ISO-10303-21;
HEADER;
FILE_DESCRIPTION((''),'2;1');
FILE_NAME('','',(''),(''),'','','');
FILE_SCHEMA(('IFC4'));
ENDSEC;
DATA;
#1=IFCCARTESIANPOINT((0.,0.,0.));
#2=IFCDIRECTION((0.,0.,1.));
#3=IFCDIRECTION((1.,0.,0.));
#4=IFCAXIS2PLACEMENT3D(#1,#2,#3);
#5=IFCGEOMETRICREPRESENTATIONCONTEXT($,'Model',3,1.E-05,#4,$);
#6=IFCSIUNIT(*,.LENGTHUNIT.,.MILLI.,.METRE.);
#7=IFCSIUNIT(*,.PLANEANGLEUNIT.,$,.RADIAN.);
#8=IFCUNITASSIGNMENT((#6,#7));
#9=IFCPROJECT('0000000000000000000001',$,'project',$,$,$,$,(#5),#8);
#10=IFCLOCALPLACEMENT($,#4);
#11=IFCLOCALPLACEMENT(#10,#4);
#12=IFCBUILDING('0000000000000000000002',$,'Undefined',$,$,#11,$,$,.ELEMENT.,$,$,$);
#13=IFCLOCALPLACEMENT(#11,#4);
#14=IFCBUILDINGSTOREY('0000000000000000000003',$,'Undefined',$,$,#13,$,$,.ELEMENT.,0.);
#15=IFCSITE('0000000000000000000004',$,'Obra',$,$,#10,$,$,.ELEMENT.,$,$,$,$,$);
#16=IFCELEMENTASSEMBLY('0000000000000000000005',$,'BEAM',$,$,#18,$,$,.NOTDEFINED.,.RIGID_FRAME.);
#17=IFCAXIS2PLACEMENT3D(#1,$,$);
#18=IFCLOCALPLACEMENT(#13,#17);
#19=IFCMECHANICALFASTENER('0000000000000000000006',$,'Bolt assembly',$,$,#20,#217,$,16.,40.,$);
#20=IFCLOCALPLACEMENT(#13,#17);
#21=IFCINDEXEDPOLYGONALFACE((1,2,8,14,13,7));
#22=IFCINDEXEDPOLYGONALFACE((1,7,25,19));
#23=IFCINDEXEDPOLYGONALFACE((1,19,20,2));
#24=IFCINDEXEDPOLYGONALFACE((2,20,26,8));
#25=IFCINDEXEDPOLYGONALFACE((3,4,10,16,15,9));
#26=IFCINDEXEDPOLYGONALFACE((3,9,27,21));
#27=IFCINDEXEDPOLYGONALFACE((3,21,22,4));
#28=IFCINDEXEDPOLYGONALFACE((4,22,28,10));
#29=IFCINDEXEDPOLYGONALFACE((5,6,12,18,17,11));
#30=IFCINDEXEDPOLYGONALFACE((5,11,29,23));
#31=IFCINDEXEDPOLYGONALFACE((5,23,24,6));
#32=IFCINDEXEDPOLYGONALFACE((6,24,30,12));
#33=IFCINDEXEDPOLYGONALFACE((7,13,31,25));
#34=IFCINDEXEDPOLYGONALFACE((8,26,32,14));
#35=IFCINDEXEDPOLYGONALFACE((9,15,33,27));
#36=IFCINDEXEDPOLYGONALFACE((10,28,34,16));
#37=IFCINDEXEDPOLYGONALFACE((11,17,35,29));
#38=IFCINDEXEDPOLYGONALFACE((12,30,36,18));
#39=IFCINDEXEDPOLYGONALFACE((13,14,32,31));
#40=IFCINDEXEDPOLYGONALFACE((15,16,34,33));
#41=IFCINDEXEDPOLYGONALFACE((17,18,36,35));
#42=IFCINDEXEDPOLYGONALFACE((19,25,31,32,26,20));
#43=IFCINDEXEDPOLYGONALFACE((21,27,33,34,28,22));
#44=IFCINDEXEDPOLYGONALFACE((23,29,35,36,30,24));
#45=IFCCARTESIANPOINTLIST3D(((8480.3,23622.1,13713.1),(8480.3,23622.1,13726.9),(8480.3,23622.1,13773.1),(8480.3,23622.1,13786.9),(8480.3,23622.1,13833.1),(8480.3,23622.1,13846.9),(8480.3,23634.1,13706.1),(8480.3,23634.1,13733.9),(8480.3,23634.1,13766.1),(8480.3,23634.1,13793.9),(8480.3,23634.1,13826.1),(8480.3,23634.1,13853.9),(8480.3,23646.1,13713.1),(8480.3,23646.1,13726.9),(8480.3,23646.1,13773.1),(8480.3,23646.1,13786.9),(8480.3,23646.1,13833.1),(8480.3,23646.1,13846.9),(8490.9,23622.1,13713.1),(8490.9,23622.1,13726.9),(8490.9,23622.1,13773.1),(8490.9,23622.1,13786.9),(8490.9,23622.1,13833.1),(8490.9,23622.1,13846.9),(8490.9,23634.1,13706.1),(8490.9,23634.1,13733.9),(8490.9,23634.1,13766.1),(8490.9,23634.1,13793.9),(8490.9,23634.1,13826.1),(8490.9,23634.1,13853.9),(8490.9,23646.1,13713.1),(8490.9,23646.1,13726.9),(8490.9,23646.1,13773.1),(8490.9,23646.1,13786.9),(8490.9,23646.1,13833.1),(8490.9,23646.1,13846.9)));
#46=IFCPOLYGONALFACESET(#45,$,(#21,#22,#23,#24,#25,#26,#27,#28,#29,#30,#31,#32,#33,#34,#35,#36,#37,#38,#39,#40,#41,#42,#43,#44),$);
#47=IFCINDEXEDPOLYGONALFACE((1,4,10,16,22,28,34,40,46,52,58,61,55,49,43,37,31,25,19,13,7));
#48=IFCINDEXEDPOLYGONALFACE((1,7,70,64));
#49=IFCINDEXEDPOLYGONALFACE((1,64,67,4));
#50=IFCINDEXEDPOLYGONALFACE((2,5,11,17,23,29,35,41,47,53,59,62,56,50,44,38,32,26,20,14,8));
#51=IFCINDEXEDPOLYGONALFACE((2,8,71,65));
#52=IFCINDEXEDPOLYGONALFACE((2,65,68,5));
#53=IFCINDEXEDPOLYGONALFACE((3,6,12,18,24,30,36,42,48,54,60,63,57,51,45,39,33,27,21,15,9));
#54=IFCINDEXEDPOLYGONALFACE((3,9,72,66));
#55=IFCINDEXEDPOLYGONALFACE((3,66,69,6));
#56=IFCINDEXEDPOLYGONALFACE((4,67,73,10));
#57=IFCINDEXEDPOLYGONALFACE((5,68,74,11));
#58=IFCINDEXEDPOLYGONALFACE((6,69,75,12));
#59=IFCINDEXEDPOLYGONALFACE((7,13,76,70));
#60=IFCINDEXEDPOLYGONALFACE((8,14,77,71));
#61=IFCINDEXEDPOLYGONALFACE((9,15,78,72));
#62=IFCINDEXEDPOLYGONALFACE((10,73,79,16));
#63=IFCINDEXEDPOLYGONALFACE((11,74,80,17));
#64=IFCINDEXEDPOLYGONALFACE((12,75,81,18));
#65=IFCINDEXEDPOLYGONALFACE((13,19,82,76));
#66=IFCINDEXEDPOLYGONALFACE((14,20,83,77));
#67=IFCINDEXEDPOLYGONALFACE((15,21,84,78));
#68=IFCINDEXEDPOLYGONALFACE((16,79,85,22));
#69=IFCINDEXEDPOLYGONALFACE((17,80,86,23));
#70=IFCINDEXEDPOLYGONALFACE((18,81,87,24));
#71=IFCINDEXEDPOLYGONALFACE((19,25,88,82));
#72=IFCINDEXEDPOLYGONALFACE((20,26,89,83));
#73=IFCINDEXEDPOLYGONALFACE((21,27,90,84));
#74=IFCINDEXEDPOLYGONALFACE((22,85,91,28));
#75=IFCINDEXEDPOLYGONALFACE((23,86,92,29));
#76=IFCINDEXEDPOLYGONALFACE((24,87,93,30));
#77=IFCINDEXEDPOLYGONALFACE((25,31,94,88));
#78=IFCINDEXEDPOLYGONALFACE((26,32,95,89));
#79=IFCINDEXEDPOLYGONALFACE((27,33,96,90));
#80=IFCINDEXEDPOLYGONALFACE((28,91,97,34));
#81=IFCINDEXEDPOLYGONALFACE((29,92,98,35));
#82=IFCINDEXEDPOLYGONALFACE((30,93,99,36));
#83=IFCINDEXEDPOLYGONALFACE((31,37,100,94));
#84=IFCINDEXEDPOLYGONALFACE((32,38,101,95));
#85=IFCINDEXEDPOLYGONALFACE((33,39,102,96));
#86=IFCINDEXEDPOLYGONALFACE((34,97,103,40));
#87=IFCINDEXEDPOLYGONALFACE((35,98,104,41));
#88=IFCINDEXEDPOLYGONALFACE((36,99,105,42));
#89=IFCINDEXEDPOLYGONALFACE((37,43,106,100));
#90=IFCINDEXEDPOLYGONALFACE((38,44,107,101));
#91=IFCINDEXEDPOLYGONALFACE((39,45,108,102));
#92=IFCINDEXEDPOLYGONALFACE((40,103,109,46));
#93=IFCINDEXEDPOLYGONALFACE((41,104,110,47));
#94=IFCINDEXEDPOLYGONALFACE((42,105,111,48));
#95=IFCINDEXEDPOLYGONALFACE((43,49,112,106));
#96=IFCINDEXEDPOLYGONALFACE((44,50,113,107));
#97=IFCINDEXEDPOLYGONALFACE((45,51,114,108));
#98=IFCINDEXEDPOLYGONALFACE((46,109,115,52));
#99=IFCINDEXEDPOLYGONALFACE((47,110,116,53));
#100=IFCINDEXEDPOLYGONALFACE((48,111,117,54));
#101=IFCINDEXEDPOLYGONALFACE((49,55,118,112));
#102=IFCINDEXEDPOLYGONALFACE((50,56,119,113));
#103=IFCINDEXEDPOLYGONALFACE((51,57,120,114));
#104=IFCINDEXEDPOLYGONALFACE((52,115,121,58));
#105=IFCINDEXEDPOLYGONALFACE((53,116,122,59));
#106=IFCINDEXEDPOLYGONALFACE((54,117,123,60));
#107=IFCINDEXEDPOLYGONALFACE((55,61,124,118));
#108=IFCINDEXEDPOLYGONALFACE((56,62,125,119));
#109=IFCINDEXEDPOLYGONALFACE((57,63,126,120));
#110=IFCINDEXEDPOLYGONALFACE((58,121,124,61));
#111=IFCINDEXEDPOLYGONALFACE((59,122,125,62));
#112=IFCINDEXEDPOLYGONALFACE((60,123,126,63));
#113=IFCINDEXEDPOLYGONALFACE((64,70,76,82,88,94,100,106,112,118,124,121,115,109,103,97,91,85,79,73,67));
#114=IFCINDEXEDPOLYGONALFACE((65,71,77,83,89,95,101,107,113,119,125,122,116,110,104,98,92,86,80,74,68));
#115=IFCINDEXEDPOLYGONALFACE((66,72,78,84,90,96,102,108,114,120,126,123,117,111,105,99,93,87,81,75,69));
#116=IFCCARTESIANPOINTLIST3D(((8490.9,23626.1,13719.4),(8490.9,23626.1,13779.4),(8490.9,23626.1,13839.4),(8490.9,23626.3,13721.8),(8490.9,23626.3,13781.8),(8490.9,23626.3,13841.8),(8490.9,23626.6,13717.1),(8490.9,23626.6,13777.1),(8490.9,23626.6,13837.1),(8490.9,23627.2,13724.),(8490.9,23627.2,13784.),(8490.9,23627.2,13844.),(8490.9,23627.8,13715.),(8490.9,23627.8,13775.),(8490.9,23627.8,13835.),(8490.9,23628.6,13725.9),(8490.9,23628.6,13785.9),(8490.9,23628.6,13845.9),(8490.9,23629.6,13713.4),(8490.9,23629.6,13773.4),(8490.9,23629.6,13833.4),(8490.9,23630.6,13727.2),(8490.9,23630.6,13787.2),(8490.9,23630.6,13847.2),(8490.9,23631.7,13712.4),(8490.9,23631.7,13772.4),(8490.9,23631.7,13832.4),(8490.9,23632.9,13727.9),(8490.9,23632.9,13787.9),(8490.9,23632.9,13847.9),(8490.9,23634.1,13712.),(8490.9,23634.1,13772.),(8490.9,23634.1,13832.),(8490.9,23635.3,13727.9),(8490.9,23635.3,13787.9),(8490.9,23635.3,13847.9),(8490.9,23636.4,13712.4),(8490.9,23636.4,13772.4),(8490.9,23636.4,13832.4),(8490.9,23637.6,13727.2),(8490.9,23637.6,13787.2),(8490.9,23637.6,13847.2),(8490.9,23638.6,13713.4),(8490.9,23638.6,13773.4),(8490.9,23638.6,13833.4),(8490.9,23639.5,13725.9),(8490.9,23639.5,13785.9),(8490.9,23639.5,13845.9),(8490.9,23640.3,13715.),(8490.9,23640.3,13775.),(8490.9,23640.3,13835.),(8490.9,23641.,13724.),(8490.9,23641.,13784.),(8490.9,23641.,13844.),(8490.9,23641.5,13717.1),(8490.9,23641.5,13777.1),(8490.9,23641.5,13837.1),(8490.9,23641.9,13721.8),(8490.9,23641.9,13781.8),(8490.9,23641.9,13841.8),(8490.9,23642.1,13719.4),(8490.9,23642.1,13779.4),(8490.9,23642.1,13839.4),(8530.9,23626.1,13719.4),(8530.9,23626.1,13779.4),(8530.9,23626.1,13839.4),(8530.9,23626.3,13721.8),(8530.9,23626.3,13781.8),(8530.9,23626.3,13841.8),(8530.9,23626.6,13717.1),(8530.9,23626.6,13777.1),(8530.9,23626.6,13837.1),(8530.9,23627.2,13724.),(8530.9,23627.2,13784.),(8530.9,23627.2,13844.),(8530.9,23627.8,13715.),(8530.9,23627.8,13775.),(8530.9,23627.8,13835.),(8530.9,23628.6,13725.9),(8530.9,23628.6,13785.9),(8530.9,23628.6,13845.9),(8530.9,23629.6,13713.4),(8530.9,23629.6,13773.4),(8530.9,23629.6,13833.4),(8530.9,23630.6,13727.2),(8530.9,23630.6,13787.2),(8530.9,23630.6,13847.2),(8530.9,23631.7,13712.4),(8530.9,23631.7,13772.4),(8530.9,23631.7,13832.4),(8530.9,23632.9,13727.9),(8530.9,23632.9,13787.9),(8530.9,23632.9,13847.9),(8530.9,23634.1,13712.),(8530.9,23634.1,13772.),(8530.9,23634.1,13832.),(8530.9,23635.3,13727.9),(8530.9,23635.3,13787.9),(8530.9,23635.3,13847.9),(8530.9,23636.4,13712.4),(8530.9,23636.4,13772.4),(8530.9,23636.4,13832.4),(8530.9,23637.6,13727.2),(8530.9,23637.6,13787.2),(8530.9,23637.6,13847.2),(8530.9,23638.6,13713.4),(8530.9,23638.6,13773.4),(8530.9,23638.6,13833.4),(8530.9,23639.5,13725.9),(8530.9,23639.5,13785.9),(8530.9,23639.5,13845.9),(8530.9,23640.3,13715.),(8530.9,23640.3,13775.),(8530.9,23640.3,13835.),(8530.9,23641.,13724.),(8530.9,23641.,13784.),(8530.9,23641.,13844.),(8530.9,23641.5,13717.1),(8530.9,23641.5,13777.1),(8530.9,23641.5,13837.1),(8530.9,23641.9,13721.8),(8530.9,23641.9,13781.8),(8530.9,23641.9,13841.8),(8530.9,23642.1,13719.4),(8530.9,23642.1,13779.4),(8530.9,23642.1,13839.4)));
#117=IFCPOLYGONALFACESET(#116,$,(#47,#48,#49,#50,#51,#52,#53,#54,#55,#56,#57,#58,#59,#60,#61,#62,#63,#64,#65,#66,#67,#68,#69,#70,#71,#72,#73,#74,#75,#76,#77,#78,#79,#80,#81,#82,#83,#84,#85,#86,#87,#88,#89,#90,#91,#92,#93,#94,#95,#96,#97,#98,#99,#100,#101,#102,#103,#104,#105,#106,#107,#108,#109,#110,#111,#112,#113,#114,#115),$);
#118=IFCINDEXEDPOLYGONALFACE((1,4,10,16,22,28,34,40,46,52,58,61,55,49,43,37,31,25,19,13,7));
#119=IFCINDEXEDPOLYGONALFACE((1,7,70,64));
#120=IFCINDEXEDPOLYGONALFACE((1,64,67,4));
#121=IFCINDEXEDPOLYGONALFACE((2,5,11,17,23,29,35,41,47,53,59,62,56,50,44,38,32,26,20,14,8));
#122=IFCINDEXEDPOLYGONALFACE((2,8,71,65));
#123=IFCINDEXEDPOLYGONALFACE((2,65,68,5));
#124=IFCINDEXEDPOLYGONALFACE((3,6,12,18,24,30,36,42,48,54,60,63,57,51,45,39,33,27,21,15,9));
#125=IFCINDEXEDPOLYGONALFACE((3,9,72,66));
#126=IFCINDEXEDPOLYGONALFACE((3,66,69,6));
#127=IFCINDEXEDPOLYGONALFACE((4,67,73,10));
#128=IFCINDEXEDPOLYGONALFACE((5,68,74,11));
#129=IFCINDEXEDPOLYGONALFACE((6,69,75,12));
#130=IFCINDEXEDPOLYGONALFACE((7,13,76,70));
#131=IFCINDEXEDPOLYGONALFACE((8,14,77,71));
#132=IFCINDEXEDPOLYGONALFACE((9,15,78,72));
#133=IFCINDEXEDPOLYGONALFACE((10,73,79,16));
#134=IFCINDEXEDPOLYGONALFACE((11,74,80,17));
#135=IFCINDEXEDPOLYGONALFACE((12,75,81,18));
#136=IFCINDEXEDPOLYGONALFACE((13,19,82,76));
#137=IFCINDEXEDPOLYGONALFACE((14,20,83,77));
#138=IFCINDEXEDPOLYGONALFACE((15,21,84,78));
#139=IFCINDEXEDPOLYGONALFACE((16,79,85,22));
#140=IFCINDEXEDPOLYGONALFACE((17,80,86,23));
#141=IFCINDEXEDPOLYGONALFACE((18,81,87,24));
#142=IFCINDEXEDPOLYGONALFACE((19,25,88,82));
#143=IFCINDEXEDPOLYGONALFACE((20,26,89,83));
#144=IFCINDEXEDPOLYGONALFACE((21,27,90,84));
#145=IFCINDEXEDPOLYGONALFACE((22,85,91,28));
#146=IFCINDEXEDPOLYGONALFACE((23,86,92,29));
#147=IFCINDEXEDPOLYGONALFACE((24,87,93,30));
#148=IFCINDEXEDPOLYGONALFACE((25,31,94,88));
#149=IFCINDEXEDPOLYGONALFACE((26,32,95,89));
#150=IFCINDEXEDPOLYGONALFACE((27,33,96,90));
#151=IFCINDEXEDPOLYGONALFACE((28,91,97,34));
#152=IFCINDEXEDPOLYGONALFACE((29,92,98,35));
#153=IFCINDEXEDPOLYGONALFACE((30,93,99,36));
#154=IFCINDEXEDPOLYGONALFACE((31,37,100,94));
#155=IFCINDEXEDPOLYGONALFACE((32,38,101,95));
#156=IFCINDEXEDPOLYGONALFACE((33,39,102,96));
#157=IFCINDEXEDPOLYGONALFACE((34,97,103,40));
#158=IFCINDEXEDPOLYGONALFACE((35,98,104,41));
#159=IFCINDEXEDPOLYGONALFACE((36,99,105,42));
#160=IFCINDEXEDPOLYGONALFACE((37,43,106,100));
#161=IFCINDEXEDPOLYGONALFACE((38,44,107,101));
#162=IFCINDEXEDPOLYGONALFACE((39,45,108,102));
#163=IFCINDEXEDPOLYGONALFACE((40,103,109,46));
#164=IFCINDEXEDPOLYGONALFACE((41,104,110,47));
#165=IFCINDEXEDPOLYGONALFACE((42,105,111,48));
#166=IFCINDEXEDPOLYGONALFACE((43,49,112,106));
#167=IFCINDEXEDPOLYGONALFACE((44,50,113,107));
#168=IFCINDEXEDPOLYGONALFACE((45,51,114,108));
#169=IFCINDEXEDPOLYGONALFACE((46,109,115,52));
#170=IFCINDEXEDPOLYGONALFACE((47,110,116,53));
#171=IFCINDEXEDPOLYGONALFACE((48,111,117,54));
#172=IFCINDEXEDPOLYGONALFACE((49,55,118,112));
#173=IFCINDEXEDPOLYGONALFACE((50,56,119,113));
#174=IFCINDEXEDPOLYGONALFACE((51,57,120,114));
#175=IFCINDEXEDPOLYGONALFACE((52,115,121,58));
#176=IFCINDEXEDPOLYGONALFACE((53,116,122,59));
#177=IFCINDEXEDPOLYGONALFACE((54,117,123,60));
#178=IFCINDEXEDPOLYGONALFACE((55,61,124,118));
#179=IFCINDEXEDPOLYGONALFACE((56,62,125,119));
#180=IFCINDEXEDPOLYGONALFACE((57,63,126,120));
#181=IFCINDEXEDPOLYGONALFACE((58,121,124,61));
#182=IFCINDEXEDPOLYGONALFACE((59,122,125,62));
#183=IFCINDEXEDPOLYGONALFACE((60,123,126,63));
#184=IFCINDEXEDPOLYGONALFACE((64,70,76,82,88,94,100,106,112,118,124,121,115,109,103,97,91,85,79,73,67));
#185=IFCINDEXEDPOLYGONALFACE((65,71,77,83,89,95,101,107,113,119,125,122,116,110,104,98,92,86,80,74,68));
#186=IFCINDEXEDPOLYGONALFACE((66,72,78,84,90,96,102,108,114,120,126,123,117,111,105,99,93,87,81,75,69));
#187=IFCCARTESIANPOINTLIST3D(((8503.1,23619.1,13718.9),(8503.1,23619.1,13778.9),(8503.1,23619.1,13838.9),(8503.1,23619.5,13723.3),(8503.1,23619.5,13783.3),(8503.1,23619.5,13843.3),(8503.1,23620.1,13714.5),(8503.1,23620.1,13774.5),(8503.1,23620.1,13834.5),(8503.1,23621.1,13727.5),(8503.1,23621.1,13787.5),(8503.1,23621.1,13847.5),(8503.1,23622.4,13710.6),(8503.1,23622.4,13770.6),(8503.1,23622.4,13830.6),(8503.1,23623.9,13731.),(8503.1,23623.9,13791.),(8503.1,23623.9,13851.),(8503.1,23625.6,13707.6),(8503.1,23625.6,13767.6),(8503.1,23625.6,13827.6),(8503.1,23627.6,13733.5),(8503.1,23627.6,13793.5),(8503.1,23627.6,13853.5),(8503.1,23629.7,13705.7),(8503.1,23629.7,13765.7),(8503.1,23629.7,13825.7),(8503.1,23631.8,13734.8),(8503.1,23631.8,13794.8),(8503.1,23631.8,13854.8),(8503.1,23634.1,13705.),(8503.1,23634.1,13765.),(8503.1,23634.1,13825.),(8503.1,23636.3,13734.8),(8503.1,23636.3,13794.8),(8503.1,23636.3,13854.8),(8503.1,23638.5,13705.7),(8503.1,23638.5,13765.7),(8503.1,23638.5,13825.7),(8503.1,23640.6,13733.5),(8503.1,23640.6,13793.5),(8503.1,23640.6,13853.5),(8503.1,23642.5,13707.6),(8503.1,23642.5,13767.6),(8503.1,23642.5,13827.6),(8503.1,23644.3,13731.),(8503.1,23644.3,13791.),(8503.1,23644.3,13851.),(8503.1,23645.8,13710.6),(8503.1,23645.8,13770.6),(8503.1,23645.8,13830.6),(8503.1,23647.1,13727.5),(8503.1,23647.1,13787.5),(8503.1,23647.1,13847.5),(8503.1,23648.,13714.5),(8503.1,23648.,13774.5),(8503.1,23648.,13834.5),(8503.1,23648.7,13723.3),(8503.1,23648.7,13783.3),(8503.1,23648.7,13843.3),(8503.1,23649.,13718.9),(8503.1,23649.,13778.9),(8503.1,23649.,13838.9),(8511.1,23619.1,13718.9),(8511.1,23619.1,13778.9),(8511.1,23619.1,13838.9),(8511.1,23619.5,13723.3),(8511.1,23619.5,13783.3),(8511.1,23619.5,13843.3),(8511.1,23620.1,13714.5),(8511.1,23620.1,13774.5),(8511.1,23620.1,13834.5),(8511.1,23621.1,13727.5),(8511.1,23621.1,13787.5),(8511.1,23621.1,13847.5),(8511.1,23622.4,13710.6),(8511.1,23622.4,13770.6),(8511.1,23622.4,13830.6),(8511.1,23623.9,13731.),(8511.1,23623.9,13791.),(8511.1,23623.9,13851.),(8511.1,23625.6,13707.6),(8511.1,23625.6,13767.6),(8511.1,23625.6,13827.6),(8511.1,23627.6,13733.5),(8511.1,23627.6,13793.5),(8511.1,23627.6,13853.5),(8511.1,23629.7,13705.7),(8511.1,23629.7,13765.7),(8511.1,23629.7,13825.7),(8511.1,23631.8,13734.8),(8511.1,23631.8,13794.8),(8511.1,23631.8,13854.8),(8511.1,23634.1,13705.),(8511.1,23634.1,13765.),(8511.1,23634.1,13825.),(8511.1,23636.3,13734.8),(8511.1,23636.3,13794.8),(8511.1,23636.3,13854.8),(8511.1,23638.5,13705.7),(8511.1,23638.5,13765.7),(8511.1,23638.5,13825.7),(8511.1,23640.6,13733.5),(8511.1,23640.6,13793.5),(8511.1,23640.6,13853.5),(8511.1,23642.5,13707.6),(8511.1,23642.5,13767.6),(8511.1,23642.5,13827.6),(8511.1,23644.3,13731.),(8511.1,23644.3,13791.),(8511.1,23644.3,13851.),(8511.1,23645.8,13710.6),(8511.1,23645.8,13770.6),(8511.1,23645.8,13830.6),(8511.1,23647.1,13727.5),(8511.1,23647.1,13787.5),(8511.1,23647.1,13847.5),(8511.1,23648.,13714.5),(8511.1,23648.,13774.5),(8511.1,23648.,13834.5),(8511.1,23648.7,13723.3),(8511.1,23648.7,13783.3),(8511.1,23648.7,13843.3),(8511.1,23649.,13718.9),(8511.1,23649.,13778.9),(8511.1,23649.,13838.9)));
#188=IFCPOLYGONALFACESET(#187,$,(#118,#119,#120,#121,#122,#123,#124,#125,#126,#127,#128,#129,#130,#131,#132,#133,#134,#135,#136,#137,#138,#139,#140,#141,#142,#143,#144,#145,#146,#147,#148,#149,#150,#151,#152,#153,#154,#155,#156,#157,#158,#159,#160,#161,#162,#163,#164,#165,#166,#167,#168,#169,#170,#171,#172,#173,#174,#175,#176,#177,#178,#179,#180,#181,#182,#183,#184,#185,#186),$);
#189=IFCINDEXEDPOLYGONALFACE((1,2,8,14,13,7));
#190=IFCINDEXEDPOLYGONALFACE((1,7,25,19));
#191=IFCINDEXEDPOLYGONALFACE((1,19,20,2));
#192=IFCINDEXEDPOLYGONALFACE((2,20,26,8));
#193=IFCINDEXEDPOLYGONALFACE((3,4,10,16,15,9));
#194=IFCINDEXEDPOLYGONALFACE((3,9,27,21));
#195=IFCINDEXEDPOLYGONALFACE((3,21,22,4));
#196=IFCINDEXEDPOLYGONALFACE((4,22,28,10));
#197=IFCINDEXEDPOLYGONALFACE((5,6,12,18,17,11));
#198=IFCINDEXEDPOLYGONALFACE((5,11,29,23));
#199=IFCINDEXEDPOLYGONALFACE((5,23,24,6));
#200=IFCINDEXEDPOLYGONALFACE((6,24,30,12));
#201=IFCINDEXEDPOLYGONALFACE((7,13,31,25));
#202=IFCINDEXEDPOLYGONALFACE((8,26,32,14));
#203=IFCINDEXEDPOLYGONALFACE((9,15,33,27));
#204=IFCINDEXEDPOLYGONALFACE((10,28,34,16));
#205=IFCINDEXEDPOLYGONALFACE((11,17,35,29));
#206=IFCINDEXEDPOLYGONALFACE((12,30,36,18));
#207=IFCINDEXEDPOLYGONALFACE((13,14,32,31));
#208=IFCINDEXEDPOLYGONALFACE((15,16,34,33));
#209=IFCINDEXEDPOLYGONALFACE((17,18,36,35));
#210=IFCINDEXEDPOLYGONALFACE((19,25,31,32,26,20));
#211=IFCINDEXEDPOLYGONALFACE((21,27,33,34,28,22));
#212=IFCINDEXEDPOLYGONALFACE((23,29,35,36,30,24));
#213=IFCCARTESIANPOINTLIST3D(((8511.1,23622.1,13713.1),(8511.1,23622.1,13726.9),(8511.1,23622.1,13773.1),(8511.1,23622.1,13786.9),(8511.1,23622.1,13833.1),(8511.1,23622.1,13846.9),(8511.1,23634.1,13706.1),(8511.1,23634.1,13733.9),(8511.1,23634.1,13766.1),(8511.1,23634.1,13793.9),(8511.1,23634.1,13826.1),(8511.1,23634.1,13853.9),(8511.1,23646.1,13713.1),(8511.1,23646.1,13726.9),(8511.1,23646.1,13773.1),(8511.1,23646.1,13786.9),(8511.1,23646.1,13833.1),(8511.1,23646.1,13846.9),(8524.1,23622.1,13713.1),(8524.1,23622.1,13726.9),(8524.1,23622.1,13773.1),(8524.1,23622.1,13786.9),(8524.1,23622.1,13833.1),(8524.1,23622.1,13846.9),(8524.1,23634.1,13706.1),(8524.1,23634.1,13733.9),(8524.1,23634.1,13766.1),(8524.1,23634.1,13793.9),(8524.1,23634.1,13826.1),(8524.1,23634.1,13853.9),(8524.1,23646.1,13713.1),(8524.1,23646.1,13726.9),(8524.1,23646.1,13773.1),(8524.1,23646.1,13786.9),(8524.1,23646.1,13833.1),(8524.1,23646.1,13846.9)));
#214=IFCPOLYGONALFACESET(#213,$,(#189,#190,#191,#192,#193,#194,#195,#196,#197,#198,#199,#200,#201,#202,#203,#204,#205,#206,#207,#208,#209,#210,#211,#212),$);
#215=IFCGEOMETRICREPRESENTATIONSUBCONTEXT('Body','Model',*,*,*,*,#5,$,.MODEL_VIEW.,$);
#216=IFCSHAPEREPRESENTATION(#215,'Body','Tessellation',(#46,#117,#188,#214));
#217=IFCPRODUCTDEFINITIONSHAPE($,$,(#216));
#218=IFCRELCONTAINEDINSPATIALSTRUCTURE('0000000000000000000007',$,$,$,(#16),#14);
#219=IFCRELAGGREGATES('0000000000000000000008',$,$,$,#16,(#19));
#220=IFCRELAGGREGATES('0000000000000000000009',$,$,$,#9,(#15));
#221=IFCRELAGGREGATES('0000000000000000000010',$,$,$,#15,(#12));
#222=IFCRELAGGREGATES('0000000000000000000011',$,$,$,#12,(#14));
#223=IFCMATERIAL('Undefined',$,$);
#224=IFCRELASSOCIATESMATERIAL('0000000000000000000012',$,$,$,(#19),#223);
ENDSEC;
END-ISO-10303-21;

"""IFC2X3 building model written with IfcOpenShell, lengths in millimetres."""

from ifc_helpers import new_model, si_unit, frame, origin_with_axes, origin_2d_with_axis, place, context, subcontext, project, spatial, polyline, circle, outline, extrude, source, transform, mapped, material, element, aggregate, save


model = new_model("IFC2X3")

# Units and contexts
model_context = context("Model", 3, precision=1e-05, world=origin_with_axes())
body_context = subcontext(model_context, "Body", "Model", "MODEL_VIEW")
ifc_project = project(units=[si_unit("LENGTHUNIT", "METRE", prefix="MILLI"), si_unit("PLANEANGLEUNIT", "RADIAN")], contexts=[model_context])

# Site, building, storey
site_placement = place(None, origin_with_axes())
site = spatial("IfcSite", under=ifc_project, at=site_placement, Name="Obra", CompositionType="ELEMENT")
building_placement = place(site_placement, origin_with_axes())
building = spatial("IfcBuilding", under=site, at=building_placement, Name="Undefined", CompositionType="ELEMENT")
storey_placement = place(building_placement, origin_with_axes())
storey = spatial("IfcBuildingStorey", under=building, at=storey_placement, Name="Undefined", CompositionType="ELEMENT", Elevation=0.0)

# Shared definitions
ifc_material_1 = material(Name="Undefined")

# Element assembly, mechanical fastener
assembly_1_placement = place(storey_placement, origin_with_axes())
assembly_1 = element("IfcElementAssembly", 1, at=assembly_1_placement, inside=storey, Name="BEAM", AssemblyPlace="NOTDEFINED", PredefinedType="RIGID_FRAME")
shared_shape_1 = source(origin_with_axes(), body_context, "Body", "SweptSolid", [
    extrude(outline(polyline([(13.9, 0.0), (6.9, 12.0), (-6.9, 12.0), (-13.9, 0.0), (-6.9, -12.0), (6.9, -12.0), (13.9, 0.0)])), frame((0.0, -19.7, 0.0), z_axis=(0.0, 1.0, 0.0), x_axis=(1.0, 0.0, 0.0)), (0.0, 0.0, 1.0), 10.6),
    extrude(circle(Radius=8.0, at=origin_2d_with_axis()), frame((0.0, -9.1, 0.0), z_axis=(0.0, 1.0, 0.0), x_axis=(1.0, 0.0, 0.0)), (0.0, 0.0, 1.0), 40.0),
    extrude(circle(Radius=15.0, at=origin_2d_with_axis()), frame((0.0, 3.1, 0.0), z_axis=(0.0, 1.0, 0.0), x_axis=(1.0, 0.0, 0.0)), (0.0, 0.0, 1.0), 8.0),
    extrude(outline(polyline([(13.9, 0.0), (6.9, 12.0), (-6.9, 12.0), (-13.9, 0.0), (-6.9, -12.0), (6.9, -12.0), (13.9, 0.0)])), frame((0.0, 11.1, 0.0), z_axis=(0.0, 1.0, 0.0), x_axis=(1.0, 0.0, 0.0)), (0.0, 0.0, 1.0), 13.0),
])
mechanical_fastener_1_placement = place(assembly_1_placement, frame((8500.0, 23684.1, 13900.0), z_axis=(0.0, -1.0, 0.0), x_axis=(0.0, 0.0, -1.0)))
mechanical_fastener_1 = element("IfcMechanicalFastener", 2, at=mechanical_fastener_1_placement, material=ifc_material_1, Name="Bolt assembly", NominalDiameter=16.0, NominalLength=40.0, context=body_context, shape_type="MappedRepresentation", body=[
    mapped(shared_shape_1, transform((60.0, 0.0, 50.0))),
    mapped(shared_shape_1, transform((120.0, 0.0, 50.0))),
    mapped(shared_shape_1, transform((180.0, 0.0, 50.0))),
])
aggregate(assembly_1, [mechanical_fastener_1])

save(model, "model.ifc")
